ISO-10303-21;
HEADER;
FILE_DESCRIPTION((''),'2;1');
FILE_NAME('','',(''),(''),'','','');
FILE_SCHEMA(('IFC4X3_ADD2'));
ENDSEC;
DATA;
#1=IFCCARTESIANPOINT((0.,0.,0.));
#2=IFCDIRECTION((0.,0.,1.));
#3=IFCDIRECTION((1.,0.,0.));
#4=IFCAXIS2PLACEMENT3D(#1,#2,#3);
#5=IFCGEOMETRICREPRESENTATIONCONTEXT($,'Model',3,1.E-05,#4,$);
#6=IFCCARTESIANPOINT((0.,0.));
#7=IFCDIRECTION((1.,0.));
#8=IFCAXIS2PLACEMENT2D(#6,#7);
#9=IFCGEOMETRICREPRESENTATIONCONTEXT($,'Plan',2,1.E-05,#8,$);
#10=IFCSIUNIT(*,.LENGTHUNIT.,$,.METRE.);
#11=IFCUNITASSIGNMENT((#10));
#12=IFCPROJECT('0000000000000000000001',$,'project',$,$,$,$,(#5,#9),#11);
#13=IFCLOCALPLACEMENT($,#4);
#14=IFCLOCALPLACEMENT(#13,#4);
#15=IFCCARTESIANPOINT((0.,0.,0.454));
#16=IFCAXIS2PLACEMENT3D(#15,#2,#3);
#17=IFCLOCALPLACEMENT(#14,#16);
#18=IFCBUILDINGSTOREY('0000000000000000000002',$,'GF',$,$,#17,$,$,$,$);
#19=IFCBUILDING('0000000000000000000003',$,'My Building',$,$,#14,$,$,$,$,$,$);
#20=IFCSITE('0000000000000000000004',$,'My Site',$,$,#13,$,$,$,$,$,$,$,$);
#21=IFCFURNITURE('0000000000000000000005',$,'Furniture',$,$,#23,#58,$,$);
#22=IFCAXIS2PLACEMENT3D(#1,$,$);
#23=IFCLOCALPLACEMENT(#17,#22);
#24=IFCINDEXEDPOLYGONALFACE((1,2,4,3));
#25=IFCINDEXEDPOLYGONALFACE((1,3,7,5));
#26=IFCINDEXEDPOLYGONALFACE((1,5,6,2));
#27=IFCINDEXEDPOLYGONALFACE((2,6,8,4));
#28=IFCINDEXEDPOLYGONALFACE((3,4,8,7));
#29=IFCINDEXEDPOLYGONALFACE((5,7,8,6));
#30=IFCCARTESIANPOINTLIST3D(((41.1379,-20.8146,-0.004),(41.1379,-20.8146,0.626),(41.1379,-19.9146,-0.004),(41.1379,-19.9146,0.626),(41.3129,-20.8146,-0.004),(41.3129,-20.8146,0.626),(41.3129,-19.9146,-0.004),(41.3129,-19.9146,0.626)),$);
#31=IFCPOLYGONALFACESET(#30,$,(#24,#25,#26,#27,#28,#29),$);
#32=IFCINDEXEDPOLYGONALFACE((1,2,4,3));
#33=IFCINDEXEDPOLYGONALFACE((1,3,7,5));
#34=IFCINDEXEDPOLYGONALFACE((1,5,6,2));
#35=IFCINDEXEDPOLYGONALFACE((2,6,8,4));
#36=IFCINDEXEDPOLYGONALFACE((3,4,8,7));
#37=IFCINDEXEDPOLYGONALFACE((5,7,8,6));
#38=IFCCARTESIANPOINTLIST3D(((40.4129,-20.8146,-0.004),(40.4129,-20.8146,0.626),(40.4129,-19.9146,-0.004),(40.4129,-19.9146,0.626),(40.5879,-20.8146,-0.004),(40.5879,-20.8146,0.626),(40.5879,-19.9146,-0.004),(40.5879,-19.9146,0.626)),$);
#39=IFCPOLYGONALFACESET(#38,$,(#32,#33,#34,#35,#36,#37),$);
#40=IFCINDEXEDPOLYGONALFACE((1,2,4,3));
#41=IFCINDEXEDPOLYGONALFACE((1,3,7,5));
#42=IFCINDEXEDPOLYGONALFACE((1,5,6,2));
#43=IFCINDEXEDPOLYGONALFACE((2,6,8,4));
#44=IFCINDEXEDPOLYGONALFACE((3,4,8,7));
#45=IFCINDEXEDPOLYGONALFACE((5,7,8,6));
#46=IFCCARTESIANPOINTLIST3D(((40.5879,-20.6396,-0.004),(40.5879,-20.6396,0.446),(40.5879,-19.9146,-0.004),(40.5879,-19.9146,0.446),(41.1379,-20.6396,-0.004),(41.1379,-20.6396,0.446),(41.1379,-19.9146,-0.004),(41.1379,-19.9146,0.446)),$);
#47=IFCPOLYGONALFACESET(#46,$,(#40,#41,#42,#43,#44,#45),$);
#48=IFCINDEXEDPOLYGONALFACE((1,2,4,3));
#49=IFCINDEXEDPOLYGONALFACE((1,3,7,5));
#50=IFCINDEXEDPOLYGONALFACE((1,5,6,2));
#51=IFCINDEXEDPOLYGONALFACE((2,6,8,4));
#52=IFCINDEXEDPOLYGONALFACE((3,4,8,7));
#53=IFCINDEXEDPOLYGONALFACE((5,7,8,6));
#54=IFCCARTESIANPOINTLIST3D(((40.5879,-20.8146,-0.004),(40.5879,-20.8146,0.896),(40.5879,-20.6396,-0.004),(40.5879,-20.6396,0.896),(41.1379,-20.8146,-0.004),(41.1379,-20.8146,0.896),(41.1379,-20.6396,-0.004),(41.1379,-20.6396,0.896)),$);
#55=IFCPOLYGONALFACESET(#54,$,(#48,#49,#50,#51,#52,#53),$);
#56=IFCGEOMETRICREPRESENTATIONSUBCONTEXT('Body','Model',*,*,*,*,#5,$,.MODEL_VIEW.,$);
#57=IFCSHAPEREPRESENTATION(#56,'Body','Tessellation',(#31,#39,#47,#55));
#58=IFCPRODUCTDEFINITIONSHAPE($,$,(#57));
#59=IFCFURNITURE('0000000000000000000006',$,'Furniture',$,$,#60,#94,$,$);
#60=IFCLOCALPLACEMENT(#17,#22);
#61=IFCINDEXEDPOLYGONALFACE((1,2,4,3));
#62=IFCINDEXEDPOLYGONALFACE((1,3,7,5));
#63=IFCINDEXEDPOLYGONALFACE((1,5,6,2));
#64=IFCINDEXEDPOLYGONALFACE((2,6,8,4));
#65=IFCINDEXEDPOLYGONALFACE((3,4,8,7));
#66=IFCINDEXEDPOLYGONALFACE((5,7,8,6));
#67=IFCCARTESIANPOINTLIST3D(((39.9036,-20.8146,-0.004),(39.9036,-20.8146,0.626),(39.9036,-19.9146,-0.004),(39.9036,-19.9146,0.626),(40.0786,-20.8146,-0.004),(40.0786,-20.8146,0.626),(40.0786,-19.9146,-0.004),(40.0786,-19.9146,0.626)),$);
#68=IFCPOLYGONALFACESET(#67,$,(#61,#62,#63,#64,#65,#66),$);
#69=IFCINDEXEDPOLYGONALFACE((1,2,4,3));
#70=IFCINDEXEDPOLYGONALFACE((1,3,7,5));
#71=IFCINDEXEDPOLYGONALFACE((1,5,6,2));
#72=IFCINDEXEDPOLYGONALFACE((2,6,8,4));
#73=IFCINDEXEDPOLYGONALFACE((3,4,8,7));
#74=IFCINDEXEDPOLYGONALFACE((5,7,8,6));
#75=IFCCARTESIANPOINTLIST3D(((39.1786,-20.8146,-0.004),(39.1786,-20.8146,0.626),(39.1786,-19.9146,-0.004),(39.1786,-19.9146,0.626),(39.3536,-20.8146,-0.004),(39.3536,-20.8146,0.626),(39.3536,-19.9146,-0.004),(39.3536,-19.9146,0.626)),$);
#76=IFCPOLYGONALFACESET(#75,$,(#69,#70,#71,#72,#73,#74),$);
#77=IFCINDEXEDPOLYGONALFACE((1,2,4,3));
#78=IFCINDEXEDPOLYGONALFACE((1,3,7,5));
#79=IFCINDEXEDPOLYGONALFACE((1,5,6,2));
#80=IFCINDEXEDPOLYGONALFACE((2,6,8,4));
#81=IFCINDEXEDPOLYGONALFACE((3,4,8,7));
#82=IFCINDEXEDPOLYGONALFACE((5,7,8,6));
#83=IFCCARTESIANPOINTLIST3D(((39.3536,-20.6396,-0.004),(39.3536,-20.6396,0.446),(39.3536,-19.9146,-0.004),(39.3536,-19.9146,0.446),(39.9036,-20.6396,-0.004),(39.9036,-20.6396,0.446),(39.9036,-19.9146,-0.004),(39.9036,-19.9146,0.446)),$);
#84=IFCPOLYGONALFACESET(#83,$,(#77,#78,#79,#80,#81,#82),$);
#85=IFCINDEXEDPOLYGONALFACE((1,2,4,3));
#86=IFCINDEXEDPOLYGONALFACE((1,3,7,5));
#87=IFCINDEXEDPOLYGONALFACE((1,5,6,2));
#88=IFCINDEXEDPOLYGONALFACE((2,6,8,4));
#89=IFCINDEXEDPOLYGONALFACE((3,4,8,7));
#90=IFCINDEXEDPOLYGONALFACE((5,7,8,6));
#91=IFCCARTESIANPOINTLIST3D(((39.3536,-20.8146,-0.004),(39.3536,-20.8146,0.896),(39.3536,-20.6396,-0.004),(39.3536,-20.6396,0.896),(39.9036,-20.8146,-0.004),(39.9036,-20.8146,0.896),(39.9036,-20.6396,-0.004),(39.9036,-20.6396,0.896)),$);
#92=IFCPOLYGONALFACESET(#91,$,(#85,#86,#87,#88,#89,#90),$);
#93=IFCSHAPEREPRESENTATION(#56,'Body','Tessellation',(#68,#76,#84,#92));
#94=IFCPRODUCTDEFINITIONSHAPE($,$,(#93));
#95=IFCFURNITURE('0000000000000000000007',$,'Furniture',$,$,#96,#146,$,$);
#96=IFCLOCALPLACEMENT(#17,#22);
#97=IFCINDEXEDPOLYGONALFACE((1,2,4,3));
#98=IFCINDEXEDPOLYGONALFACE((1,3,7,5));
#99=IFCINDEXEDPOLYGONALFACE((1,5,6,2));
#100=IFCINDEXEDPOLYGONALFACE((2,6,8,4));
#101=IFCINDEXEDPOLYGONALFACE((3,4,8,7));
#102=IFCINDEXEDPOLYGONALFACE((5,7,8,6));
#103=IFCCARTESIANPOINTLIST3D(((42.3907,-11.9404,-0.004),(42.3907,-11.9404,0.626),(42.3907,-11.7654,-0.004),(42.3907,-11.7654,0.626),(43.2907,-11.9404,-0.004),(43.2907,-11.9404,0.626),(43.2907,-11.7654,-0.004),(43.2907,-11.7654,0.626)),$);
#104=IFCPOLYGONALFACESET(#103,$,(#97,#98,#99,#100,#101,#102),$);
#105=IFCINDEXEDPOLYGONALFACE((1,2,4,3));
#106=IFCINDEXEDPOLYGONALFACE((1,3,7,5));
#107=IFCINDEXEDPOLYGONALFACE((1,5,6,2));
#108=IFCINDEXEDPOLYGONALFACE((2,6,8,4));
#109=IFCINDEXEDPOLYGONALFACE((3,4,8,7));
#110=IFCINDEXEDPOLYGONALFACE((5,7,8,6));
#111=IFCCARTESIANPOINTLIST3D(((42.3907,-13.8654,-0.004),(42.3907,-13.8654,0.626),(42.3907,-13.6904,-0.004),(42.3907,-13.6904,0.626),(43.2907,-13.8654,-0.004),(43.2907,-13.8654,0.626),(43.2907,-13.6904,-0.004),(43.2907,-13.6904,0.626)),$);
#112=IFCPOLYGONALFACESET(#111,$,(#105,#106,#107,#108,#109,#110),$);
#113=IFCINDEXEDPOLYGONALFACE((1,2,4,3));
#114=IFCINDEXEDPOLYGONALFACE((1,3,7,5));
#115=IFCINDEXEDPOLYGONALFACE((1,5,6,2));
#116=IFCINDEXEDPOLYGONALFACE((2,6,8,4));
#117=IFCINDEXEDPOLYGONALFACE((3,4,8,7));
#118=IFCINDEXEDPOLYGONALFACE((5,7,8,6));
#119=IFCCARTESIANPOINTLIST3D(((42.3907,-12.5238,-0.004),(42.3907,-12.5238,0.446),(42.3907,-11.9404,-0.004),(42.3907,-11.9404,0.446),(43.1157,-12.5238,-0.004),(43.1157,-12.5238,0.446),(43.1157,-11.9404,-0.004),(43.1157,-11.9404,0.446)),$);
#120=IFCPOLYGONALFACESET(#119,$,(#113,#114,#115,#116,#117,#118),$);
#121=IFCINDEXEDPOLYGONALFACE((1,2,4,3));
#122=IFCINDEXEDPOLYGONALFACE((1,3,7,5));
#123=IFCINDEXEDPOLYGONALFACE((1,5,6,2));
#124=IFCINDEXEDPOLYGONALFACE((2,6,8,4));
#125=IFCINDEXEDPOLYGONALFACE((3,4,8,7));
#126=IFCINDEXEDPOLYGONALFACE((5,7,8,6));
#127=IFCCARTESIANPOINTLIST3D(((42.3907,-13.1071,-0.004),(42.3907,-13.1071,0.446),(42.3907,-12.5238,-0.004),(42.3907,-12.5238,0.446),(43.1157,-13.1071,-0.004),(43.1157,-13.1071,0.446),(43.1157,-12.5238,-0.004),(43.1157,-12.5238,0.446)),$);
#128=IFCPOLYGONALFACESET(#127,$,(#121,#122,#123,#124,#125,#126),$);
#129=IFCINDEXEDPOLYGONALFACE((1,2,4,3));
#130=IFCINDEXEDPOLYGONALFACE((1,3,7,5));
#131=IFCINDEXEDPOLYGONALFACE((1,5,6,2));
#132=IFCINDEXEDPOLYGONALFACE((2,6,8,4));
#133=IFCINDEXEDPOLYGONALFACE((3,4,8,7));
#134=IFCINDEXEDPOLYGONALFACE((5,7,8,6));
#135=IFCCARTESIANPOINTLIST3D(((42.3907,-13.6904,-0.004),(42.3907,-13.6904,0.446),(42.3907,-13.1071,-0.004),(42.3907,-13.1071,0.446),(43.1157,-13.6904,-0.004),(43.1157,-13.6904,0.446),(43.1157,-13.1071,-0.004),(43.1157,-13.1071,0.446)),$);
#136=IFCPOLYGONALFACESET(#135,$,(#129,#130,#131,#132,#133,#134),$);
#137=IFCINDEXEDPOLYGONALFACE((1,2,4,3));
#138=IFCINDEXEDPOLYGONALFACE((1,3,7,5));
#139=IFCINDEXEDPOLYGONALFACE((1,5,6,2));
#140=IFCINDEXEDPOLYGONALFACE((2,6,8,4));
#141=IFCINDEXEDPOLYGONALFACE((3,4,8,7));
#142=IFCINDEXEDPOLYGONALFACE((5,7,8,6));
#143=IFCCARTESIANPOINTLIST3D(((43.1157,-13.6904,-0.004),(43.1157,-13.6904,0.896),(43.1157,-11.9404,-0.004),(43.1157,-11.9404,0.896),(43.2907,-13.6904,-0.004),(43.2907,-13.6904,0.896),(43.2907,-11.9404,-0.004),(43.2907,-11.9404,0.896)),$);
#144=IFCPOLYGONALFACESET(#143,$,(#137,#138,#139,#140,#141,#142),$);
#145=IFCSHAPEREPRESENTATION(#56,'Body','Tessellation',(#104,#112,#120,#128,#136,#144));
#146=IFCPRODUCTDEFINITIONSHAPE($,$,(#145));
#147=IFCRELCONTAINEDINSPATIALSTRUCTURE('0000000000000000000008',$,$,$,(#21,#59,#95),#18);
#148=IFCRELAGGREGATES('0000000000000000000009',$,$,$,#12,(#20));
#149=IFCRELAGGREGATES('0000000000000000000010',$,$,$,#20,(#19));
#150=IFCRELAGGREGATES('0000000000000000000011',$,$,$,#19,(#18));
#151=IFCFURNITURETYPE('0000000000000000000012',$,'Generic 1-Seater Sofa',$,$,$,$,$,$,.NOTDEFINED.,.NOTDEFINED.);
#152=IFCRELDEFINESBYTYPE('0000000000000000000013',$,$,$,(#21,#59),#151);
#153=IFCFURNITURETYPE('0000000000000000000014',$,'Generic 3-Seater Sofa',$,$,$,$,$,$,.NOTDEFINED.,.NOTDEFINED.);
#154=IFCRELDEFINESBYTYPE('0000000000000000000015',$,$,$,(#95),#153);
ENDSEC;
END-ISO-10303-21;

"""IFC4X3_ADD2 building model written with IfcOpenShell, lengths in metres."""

from ifc_helpers import new_model, entity, si_unit, frame, origin_with_axes, origin_2d_with_axis, place, context, subcontext, project, spatial, line, indexed_curve, outline, extrude, shape, source, transform, mapped, type_object, type_shapes, element, save


model = new_model("IFC4X3_ADD2")

# Units and contexts
model_context = context("Model", 3, precision=1e-05, world=origin_with_axes())
plan_context = context("Plan", 2, precision=1e-05, world=origin_2d_with_axis())
body_context_1 = subcontext(model_context, "Body", "Model", "MODEL_VIEW")
body_context_2 = subcontext(plan_context, "Body", "Plan", "PLAN_VIEW")
ifc_project = project(units=[si_unit("LENGTHUNIT", "METRE")], contexts=[model_context, plan_context])

# Site, building, storey
site_placement = place(None, origin_with_axes())
site = spatial("IfcSite", under=ifc_project, at=site_placement, Name="My Site")
building_placement = place(site_placement, origin_with_axes())
building = spatial("IfcBuilding", under=site, at=building_placement, Name="My Building")
storey_placement = place(building_placement, frame((0.0, 0.0, 0.454), z_axis=(0.0, 0.0, 1.0), x_axis=(1.0, 0.0, 0.0)))
storey = spatial("IfcBuildingStorey", under=building, at=storey_placement, Name="GF")

# Furniture
furniture_type_1 = type_object("IfcFurnitureType", Name="Generic 1-Seater Sofa", AssemblyPlace="NOTDEFINED", PredefinedType="NOTDEFINED")
shared_shape_1 = source(origin_with_axes(), body_context_1, "Body", "SweptSolid", [
    extrude(outline(indexed_curve([(0.0, 0.0), (0.175, 0.0), (0.175, 0.9), (0.0, 0.9)], segments=[line(4, 1), line(1, 2), line(2, 3), line(3, 4)], self_intersect=False)), frame((-0.45, -0.9, 0.0), z_axis=(0.0, 0.0, 1.0), x_axis=(1.0, 0.0, 0.0)), (0.0, 0.0, 1.0), 0.63),
    extrude(outline(indexed_curve([(0.0, 0.0), (0.175, 0.0), (0.175, 0.9), (0.0, 0.9)], segments=[line(1, 2, 3, 4, 1)])), frame((0.275, -0.9, 0.0), z_axis=(0.0, 0.0, 1.0), x_axis=(1.0, 0.0, 0.0)), (0.0, 0.0, 1.0), 0.63),
    extrude(outline(indexed_curve([(0.175, 0.0), (0.725, 0.0), (0.725, 0.725), (0.175, 0.725)], segments=[line(1, 2, 3, 4, 1)])), frame((-0.45, -0.9, 0.0), z_axis=(0.0, 0.0, 1.0), x_axis=(1.0, 0.0, 0.0)), (0.0, 0.0, 1.0), 0.45),
    extrude(outline(indexed_curve([(0.175, 0.725), (0.725, 0.725), (0.725, 0.9), (0.175, 0.9)], segments=[line(1, 2, 3, 4, 1)])), frame((-0.45, -0.9, 0.0), z_axis=(0.0, 0.0, 1.0), x_axis=(1.0, 0.0, 0.0)), (0.0, 0.0, 1.0), 0.9),
])
shared_shape_2 = source(origin_with_axes(), body_context_2, "Body", "Annotation2D", [
    entity("IfcGeometricCurveSet", [entity("IfcIndexedPolyCurve", entity("IfcCartesianPointList2D", [[0.275, -0.175], [0.275, -0.9], [0.45, -0.9], [0.45, 0.0], [0.275, 0.0], [0.275, -0.9], [-0.275, -0.9], [-0.275, 0.0], [-0.275, -0.175], [0.275, -0.175], [0.275, 0.0], [-0.275, 0.0], [-0.45, 0.0], [-0.45, -0.9], [-0.275, -0.9], [-0.275, -0.175]]))]),
])
type_shapes(furniture_type_1, [shared_shape_1, shared_shape_2])
for number, where, z_axis, x_axis, name in (
    (1, (40.8629, -20.8146, -0.004), (0.0, 0.0, 1.0), (-1.0, 0.0, 0.0), "Furniture"),
    (2, (39.6286, -20.8146, -0.004), (0.0, 0.0, 1.0), (-1.0, 0.0, 0.0), "Furniture"),
):
    element("IfcFurniture", number, at=place(storey_placement, frame(where, z_axis=z_axis, x_axis=x_axis)), inside=storey, type_object=furniture_type_1, Name=name, shapes=[
        shape(body_context_1, "Body", "MappedRepresentation", [mapped(shared_shape_1, transform((0.0, 0.0, 0.0), x_axis=(1.0, 0.0, 0.0), y_axis=(0.0, 1.0, 0.0), z_axis=(0.0, 0.0, 1.0), scale=1.0))]),
        shape(body_context_2, "Body", "MappedRepresentation", [mapped(shared_shape_2, transform((0.0, 0.0, 0.0), x_axis=(1.0, 0.0, 0.0), y_axis=(0.0, 1.0, 0.0), z_axis=(0.0, 0.0, 1.0), scale=1.0))]),
    ])
furniture_type_2 = type_object("IfcFurnitureType", Name="Generic 3-Seater Sofa", AssemblyPlace="NOTDEFINED", PredefinedType="NOTDEFINED")
shared_shape_3 = source(origin_with_axes(), body_context_1, "Body", "SweptSolid", [
    extrude(outline(indexed_curve([(0.0, 0.0), (0.175, 0.0), (0.175, 0.9), (0.0, 0.9)], segments=[line(4, 1), line(1, 2), line(2, 3), line(3, 4)], self_intersect=False)), frame((-1.05, -0.9, 0.0), z_axis=(0.0, 0.0, 1.0), x_axis=(1.0, 0.0, 0.0)), (0.0, 0.0, 1.0), 0.63),
    extrude(outline(indexed_curve([(0.0, 0.0), (0.175, 0.0), (0.175, 0.9), (0.0, 0.9)], segments=[line(1, 2, 3, 4, 1)])), frame((0.875, -0.9, 0.0), z_axis=(0.0, 0.0, 1.0), x_axis=(1.0, 0.0, 0.0)), (0.0, 0.0, 1.0), 0.63),
    extrude(outline(indexed_curve([(0.175, 0.0), (0.7583, 0.0), (0.7583, 0.725), (0.175, 0.725)], segments=[line(1, 2, 3, 4, 1)])), frame((-1.05, -0.9, 0.0), z_axis=(0.0, 0.0, 1.0), x_axis=(1.0, 0.0, 0.0)), (0.0, 0.0, 1.0), 0.45),
    extrude(outline(indexed_curve([(0.7583, 0.0), (1.3417, 0.0), (1.3417, 0.725), (0.7583, 0.725)], segments=[line(1, 2, 3, 4, 1)])), frame((-1.05, -0.9, 0.0), z_axis=(0.0, 0.0, 1.0), x_axis=(1.0, 0.0, 0.0)), (0.0, 0.0, 1.0), 0.45),
    extrude(outline(indexed_curve([(1.3417, 0.0), (1.925, 0.0), (1.925, 0.725), (1.3417, 0.725)], segments=[line(1, 2, 3, 4, 1)])), frame((-1.05, -0.9, 0.0), z_axis=(0.0, 0.0, 1.0), x_axis=(1.0, 0.0, 0.0)), (0.0, 0.0, 1.0), 0.45),
    extrude(outline(indexed_curve([(0.175, 0.725), (1.925, 0.725), (1.925, 0.9), (0.175, 0.9)], segments=[line(1, 2, 3, 4, 1)])), frame((-1.05, -0.9, 0.0), z_axis=(0.0, 0.0, 1.0), x_axis=(1.0, 0.0, 0.0)), (0.0, 0.0, 1.0), 0.9),
])
shared_shape_4 = source(origin_with_axes(), body_context_2, "Body", "Annotation2D", [
    entity("IfcGeometricCurveSet", [entity("IfcIndexedPolyCurve", entity("IfcCartesianPointList2D", [[0.2917, -0.175], [0.2917, -0.9], [0.875, -0.9], [0.875, -0.175], [-0.875, -0.175], [-0.875, 0.0], [0.875, 0.0], [1.05, 0.0], [1.05, -0.9], [0.875, -0.9], [0.875, 0.0], [0.875, -0.175], [0.2917, -0.175], [-0.2917, -0.175], [-0.2917, -0.9], [-0.875, -0.9], [-0.875, 0.0], [-1.05, 0.0], [-1.05, -0.9], [-0.875, -0.9], [-0.875, -0.175], [-0.2917, -0.175]])), entity("IfcIndexedPolyCurve", entity("IfcCartesianPointList2D", [[0.2917, -0.9], [-0.2917, -0.9]]))]),
])
type_shapes(furniture_type_2, [shared_shape_3, shared_shape_4])
furniture_placement = place(storey_placement, frame((43.2907, -12.8154, -0.004), z_axis=(0.0, 0.0, 1.0), x_axis=(0.0, -1.0, 0.0)))
element("IfcFurniture", 3, at=furniture_placement, inside=storey, type_object=furniture_type_2, Name="Furniture", shapes=[
    shape(body_context_1, "Body", "MappedRepresentation", [mapped(shared_shape_3, transform((0.0, 0.0, 0.0), x_axis=(1.0, 0.0, 0.0), y_axis=(0.0, 1.0, 0.0), z_axis=(0.0, 0.0, 1.0), scale=1.0))]),
    shape(body_context_2, "Body", "MappedRepresentation", [mapped(shared_shape_4, transform((0.0, 0.0, 0.0), x_axis=(1.0, 0.0, 0.0), y_axis=(0.0, 1.0, 0.0), z_axis=(0.0, 0.0, 1.0), scale=1.0))]),
])

save(model, "model.ifc")
